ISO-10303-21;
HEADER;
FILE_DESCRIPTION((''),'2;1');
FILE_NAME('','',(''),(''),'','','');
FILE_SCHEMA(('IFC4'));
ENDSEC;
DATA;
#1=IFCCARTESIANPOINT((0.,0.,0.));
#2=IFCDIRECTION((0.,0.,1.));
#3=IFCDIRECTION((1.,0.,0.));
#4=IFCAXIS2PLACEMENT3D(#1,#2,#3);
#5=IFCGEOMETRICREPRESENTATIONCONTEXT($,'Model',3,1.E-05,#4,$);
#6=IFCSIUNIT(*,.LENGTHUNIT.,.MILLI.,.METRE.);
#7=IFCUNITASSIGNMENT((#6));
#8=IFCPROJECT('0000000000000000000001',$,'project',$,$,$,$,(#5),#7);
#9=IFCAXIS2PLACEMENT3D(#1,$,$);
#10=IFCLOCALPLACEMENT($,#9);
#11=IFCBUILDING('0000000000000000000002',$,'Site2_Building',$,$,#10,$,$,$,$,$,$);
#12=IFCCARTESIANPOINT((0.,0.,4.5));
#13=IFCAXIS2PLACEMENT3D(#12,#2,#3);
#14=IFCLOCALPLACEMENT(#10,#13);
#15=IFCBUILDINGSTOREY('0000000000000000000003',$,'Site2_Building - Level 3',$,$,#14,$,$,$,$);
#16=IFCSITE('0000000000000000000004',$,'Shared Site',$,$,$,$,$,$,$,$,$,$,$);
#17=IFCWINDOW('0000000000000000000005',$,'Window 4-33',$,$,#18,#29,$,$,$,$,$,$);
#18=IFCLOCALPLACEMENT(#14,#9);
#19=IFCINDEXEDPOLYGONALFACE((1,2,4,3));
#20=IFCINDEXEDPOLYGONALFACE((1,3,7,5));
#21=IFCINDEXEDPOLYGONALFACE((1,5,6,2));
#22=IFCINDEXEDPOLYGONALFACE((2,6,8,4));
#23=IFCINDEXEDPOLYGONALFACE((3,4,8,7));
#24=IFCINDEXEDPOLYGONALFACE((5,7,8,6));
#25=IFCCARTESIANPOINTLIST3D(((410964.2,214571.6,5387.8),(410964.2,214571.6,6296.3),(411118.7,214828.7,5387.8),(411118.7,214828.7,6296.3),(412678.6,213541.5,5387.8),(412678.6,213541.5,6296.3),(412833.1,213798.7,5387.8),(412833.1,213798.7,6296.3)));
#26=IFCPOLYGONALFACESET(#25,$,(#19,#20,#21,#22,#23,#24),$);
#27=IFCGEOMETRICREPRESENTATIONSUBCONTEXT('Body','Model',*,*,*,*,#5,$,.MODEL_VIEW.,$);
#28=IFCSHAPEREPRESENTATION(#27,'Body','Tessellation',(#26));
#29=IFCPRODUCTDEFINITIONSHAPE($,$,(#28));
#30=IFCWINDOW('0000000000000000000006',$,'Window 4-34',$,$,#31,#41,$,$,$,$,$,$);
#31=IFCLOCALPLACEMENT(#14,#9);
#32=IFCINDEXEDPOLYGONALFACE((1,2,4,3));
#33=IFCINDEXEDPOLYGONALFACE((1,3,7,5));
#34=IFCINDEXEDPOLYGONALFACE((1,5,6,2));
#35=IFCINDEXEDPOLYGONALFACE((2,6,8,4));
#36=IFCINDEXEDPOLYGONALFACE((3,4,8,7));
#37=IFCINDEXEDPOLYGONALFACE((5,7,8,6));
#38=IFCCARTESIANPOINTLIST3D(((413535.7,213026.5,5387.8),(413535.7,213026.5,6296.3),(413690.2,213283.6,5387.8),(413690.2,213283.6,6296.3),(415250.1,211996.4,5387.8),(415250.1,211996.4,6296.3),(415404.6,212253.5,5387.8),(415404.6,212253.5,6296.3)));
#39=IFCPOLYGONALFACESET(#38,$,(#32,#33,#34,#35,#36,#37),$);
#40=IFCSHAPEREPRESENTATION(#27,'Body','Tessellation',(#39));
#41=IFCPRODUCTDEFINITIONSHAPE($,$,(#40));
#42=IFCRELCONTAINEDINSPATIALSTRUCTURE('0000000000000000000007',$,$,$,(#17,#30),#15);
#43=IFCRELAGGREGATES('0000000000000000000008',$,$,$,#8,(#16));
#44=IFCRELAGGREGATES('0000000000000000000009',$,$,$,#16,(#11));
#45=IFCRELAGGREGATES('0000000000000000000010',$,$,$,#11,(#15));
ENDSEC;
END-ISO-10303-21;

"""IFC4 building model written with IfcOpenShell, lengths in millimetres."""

from ifc_helpers import new_model, si_unit, frame, origin, origin_with_axes, place, context, subcontext, project, spatial, indexed_curve, outline, extrude, element, save


model = new_model("IFC4")

# Units and contexts
model_context = context("Model", 3, precision=1e-05, world=origin_with_axes())
body_context = subcontext(model_context, "Body", "Model", "MODEL_VIEW")
ifc_project = project(units=[si_unit("LENGTHUNIT", "METRE", prefix="MILLI")], contexts=[model_context])

# Site, building, storey
site = spatial("IfcSite", under=ifc_project, Name="Shared Site")
building_placement = place(None, origin())
building = spatial("IfcBuilding", under=site, at=building_placement, Name="Site2_Building")
storey_placement = place(building_placement, frame((0.0, 0.0, 4.5), z_axis=(0.0, 0.0, 1.0), x_axis=(1.0, 0.0, 0.0)))
storey = spatial("IfcBuildingStorey", under=building, at=storey_placement, Name="Site2_Building - Level 3")

# Windows
for number, where, z_axis, x_axis, name in (
    (1, (410964.2, 214571.6, 5387.8), (0.0, 0.0, 1.0), (0.857167, -0.515038, 0.0), "Window 4-33"),
    (2, (413535.7, 213026.5, 5387.8), (0.0, 0.0, 1.0), (0.857167, -0.515038, 0.0), "Window 4-34"),
):
    element("IfcWindow", number, at=place(storey_placement, frame(where, z_axis=z_axis, x_axis=x_axis)), inside=storey, Name=name, context=body_context, shape_type="SweptSolid", body=[
        extrude(outline(indexed_curve([(0.0, 0.0), (0.0, 300.0), (2000.0, 300.0), (2000.0, 0.0), (0.0, 0.0)], self_intersect=False)), origin_with_axes(), (0.0, 0.0, 1.0), 908.6),
    ])

save(model, "model.ifc")
